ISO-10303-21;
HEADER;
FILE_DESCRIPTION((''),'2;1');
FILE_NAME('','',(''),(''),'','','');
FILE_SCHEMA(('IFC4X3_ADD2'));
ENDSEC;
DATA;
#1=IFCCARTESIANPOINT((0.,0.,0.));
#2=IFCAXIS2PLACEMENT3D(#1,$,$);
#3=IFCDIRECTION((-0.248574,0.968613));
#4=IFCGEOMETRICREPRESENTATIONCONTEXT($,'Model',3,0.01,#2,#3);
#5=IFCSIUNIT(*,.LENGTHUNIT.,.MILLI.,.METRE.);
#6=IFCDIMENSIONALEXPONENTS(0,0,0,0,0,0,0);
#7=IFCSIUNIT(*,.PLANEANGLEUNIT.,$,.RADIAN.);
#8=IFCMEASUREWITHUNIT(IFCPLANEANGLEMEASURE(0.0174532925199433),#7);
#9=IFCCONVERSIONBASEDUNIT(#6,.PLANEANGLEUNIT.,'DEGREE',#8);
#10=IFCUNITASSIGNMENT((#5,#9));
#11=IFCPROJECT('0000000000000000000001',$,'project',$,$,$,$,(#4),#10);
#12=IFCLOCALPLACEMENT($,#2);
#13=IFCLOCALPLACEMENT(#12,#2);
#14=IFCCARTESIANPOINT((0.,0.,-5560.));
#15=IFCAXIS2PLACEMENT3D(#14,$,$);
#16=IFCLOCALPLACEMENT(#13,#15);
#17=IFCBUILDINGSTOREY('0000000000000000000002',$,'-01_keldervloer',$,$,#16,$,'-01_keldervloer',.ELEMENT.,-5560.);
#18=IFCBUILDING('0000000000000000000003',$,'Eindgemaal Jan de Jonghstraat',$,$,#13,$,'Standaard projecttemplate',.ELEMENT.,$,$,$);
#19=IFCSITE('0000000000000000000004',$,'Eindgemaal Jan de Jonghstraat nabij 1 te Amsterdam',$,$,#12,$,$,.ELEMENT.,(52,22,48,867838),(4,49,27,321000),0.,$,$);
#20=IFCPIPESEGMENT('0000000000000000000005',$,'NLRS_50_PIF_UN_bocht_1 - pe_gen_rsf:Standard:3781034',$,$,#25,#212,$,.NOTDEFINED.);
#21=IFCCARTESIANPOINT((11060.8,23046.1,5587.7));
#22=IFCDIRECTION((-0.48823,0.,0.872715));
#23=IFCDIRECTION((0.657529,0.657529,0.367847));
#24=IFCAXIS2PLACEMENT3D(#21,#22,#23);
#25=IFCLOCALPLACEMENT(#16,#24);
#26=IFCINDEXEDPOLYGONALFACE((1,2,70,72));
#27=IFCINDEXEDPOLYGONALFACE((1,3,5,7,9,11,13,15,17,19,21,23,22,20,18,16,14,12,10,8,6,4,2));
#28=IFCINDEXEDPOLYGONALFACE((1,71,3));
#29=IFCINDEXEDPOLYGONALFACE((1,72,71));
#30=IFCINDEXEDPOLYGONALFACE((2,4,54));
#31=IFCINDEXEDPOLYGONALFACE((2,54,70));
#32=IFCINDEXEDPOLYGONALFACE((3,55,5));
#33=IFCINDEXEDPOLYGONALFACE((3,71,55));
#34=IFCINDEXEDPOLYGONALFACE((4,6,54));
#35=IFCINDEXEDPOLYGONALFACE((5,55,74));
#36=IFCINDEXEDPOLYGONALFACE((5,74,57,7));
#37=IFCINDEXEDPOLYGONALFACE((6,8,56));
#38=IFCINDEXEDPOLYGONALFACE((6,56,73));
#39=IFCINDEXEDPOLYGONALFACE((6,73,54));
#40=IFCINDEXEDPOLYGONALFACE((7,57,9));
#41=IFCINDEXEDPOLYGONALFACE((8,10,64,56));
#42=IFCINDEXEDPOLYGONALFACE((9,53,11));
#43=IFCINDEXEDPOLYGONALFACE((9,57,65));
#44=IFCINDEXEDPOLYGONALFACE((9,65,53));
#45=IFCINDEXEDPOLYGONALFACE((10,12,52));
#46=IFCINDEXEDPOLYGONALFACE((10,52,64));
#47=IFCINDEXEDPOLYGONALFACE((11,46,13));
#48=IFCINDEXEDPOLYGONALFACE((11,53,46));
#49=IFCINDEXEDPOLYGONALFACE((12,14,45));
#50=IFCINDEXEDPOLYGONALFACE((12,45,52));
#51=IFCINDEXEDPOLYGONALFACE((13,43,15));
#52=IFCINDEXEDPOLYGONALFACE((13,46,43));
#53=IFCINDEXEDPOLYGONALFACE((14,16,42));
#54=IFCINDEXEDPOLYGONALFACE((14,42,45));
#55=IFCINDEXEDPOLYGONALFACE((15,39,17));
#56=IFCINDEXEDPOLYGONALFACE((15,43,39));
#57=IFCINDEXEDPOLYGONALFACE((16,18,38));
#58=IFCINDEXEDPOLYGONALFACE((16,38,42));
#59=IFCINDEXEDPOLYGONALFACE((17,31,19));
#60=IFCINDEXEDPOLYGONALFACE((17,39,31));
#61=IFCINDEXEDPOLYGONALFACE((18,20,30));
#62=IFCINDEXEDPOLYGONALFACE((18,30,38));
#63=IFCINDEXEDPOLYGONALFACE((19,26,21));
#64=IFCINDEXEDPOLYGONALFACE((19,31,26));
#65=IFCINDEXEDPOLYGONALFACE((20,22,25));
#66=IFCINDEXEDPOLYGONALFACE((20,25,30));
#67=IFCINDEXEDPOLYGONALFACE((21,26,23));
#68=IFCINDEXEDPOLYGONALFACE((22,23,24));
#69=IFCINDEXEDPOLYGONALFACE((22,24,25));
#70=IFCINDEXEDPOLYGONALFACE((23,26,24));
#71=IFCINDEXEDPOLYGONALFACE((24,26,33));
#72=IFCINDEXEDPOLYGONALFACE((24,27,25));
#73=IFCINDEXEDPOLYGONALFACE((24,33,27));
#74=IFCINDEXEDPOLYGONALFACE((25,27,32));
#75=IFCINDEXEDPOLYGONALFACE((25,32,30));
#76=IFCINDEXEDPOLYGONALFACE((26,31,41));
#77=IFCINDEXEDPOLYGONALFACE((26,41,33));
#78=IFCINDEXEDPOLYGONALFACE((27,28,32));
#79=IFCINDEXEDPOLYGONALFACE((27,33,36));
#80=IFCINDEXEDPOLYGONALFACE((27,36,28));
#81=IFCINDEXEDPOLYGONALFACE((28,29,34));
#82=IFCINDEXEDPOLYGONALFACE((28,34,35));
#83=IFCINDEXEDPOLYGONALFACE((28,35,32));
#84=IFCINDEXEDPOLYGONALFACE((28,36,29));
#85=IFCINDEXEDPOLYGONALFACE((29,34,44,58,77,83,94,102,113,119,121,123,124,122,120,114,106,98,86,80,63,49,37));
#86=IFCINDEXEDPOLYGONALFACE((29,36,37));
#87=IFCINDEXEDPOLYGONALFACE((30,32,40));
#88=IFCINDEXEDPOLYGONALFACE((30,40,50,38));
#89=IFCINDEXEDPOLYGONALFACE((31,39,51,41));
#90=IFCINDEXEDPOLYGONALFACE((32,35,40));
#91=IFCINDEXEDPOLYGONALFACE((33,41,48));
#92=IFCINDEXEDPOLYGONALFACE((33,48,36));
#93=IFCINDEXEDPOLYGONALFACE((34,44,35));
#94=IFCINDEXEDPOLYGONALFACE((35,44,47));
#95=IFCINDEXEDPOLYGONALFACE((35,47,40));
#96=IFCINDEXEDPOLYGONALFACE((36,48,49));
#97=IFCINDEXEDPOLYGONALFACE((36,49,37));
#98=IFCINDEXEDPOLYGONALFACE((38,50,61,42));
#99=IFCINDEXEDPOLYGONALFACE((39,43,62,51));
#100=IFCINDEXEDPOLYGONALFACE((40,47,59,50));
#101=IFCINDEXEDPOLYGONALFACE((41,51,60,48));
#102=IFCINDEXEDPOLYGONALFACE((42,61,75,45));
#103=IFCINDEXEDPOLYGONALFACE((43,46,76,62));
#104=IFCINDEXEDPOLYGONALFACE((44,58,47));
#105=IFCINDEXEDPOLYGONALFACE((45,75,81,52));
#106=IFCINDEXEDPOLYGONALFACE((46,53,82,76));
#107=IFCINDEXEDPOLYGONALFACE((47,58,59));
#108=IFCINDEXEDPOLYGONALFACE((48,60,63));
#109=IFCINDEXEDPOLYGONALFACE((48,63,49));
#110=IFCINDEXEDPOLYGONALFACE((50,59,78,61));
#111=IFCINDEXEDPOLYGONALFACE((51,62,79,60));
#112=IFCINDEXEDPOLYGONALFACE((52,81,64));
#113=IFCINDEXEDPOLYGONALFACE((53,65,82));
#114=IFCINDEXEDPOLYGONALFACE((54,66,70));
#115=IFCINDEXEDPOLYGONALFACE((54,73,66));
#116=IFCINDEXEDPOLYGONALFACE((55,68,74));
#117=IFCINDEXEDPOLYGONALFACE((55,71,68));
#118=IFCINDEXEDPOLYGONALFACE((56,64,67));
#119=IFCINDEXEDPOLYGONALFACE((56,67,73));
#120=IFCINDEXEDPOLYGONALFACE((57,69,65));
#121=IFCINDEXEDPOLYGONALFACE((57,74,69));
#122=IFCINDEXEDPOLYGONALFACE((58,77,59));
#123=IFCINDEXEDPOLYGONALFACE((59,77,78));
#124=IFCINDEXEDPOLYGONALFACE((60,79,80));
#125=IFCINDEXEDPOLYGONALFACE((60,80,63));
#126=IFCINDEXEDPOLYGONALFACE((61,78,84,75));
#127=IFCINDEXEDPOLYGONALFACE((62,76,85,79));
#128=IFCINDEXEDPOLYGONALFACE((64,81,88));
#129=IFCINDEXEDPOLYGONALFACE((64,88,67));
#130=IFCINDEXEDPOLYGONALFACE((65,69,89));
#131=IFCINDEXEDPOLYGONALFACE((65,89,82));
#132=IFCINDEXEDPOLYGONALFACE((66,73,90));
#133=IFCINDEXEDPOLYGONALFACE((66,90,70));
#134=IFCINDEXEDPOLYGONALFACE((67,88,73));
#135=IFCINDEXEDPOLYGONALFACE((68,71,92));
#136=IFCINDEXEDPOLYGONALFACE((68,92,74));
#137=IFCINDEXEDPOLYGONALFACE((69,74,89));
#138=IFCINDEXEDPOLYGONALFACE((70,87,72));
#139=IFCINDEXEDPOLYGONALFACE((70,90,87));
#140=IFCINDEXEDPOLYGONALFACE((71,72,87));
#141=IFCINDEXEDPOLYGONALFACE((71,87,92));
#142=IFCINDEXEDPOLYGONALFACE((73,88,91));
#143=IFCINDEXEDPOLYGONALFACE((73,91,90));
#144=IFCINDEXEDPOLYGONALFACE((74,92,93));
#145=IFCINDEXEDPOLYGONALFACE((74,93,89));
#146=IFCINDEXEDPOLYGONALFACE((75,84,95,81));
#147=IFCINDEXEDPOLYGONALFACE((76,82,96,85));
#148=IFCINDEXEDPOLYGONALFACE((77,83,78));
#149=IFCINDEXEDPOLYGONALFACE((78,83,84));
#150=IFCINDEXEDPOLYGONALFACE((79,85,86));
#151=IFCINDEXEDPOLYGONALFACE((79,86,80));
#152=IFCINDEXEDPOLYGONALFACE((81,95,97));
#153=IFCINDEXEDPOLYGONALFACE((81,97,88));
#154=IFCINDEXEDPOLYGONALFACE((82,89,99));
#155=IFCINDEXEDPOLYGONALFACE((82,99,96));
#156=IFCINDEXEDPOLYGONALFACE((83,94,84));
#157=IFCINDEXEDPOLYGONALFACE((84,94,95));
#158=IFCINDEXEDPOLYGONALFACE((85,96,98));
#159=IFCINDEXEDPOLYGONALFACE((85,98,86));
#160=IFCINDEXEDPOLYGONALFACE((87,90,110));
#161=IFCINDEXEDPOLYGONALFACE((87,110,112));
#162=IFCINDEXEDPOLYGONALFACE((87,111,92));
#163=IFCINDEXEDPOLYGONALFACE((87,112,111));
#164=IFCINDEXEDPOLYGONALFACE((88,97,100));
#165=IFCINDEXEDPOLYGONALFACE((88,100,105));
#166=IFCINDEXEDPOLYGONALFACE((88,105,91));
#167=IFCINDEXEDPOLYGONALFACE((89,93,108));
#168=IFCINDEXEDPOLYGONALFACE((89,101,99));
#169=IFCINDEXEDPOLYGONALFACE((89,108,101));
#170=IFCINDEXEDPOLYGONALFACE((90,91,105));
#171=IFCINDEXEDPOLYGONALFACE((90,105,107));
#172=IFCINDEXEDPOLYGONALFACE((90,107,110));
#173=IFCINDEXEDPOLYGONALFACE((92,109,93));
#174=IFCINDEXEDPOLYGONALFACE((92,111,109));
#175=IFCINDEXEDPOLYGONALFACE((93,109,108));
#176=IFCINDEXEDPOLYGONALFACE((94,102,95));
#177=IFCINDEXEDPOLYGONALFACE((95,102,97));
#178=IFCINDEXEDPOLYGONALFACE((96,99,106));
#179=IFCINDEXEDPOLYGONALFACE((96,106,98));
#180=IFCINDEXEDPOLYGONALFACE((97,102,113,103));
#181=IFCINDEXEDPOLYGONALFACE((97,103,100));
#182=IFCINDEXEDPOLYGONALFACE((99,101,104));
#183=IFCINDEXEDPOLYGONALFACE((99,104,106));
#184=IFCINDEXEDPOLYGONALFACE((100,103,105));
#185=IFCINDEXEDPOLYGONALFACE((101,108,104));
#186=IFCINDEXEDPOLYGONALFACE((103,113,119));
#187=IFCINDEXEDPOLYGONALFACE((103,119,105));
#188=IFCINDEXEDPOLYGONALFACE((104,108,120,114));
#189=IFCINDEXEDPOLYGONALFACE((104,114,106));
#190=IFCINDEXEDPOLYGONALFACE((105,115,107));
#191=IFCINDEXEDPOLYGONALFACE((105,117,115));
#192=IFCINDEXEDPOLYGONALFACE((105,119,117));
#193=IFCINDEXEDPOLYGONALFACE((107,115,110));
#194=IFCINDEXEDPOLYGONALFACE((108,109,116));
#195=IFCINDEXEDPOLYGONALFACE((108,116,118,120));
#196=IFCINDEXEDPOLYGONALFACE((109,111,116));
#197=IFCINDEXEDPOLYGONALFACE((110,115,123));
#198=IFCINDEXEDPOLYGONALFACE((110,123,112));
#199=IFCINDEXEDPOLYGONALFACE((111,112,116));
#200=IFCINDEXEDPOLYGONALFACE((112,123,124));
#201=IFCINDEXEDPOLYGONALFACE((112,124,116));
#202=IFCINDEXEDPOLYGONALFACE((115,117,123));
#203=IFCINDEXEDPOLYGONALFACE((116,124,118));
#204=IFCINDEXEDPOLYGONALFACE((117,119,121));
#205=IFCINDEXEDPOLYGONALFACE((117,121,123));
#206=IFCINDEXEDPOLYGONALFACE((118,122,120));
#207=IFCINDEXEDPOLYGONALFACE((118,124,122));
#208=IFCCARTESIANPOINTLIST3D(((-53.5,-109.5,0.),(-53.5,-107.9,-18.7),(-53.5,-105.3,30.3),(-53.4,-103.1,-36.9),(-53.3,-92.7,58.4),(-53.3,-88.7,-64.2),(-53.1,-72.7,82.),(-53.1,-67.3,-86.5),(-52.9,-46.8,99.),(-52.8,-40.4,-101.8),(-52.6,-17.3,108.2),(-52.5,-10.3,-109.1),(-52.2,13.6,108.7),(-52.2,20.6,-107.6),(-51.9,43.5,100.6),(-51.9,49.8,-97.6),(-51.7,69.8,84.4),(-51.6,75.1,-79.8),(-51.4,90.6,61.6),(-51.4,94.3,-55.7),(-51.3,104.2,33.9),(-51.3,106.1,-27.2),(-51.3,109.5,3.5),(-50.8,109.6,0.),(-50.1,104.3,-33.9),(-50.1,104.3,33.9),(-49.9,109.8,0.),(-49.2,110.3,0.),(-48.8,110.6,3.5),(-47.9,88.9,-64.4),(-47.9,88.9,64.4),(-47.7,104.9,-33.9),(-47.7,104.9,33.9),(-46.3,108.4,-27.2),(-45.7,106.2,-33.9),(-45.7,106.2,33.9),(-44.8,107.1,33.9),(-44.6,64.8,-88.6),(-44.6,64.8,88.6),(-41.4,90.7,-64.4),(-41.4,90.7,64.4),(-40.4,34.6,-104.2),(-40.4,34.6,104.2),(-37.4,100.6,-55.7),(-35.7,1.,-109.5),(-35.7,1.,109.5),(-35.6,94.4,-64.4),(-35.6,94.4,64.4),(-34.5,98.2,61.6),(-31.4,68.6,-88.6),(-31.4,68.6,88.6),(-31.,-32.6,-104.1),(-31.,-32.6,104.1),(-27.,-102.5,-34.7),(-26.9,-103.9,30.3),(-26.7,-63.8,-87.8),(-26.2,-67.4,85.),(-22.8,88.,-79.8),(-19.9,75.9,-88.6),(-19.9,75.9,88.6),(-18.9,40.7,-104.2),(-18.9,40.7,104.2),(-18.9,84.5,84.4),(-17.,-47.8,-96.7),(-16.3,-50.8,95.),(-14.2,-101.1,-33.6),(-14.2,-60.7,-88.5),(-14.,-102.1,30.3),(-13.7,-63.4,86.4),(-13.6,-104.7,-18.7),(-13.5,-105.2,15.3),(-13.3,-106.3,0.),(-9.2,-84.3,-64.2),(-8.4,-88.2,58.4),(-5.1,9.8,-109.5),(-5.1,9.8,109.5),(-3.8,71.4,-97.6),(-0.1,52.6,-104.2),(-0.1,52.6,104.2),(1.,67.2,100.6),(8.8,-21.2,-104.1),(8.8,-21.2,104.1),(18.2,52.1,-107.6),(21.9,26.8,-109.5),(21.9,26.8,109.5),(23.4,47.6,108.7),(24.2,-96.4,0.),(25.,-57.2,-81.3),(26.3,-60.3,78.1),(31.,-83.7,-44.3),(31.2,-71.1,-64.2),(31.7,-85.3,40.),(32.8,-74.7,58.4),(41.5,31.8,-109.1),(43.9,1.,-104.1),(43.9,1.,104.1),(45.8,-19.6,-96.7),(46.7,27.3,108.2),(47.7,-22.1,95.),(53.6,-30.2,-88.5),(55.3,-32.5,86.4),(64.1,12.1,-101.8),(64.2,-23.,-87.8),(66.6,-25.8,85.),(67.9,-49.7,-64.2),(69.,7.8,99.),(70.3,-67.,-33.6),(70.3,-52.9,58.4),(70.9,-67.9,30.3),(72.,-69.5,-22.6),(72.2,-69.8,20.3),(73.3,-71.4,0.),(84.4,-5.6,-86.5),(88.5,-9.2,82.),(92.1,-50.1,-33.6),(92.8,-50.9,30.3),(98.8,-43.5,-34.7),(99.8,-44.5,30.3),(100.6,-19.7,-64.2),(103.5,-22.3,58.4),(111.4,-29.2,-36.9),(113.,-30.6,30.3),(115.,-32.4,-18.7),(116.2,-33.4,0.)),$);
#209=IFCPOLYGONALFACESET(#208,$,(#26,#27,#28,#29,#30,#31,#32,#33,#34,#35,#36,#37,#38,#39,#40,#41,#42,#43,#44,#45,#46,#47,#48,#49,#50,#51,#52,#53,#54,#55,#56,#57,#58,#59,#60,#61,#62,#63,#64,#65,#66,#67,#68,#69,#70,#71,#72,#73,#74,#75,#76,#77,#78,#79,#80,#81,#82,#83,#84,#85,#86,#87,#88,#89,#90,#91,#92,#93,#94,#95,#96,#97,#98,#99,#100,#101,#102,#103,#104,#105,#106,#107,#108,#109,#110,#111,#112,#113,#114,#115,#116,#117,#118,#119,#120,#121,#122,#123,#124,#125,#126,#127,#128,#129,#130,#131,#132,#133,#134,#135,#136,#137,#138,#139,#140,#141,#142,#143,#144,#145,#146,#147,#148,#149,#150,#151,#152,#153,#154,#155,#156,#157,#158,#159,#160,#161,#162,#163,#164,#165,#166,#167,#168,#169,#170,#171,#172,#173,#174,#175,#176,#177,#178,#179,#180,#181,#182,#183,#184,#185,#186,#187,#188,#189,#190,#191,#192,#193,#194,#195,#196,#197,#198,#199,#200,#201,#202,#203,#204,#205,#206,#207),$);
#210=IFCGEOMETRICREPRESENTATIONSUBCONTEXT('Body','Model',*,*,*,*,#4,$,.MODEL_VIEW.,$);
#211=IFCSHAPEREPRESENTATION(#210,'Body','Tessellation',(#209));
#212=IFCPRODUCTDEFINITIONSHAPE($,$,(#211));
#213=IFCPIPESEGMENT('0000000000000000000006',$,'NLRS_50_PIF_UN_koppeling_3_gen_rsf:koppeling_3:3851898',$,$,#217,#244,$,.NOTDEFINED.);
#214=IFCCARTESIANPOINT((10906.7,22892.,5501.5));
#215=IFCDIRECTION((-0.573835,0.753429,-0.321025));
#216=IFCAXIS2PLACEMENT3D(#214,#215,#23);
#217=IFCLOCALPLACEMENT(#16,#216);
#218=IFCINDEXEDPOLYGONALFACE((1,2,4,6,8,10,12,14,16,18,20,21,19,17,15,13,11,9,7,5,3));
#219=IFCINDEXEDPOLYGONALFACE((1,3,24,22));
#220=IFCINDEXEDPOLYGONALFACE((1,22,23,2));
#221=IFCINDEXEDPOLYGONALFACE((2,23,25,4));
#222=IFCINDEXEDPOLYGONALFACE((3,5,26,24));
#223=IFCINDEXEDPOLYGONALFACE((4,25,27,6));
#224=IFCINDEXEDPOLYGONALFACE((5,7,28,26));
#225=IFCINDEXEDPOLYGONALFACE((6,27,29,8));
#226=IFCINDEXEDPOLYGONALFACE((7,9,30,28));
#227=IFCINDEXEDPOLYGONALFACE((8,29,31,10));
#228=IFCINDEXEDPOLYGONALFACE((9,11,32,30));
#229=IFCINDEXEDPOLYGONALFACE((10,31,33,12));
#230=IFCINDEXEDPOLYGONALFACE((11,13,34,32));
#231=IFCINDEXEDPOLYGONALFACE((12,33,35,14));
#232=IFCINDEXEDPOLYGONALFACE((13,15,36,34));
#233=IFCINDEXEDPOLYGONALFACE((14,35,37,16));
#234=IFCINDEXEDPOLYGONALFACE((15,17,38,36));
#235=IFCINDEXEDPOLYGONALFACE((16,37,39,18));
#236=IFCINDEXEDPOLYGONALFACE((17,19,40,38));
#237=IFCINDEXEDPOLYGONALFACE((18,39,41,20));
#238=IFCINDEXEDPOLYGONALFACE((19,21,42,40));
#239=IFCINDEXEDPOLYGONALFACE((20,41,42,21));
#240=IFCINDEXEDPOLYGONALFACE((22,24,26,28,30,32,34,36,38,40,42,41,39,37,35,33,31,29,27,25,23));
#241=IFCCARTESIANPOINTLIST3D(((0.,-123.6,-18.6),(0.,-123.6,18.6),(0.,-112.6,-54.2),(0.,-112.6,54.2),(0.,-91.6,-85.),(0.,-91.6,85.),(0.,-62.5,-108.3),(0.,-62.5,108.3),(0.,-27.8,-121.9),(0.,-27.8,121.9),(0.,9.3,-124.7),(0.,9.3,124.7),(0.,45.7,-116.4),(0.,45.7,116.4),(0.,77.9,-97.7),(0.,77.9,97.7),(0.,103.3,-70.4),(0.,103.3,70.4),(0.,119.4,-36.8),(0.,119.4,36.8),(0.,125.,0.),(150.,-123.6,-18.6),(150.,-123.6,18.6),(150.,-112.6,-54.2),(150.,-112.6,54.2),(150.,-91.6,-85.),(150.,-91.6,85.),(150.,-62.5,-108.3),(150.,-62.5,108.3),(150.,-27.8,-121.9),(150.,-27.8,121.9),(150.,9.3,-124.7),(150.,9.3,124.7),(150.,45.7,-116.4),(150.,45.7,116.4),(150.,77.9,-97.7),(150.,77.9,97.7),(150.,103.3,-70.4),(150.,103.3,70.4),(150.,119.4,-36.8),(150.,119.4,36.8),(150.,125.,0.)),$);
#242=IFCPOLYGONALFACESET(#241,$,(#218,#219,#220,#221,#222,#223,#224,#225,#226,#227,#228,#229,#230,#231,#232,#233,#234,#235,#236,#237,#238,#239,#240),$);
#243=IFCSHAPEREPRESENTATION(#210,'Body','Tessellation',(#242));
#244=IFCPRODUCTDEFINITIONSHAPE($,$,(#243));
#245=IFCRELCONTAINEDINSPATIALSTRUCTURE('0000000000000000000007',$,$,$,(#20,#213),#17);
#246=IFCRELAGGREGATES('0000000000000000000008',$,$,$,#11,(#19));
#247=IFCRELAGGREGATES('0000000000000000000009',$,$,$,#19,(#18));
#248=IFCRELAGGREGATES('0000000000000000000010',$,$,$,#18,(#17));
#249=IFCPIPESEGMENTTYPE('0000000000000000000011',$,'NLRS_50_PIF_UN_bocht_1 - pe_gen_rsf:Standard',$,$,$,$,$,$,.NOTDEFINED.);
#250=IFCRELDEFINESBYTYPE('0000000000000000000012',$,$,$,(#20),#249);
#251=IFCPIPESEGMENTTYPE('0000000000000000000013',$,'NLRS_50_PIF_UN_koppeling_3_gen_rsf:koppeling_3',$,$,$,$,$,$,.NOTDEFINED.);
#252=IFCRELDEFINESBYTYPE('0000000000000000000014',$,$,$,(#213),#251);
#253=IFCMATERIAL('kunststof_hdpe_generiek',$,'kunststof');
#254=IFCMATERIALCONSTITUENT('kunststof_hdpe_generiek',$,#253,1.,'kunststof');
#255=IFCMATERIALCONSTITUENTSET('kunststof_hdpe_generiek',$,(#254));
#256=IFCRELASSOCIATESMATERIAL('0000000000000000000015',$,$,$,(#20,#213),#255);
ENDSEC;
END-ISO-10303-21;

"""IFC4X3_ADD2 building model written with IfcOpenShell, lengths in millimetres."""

from ifc_helpers import new_model, entity, si_unit, converted_unit, direction, frame, frame_2d, origin, place, context, subcontext, project, spatial, circle, extrude, source, transform, mapped, material, constituent, constituent_set, type_object, type_shapes, element, save


model = new_model("IFC4X3_ADD2")

# Units and contexts
model_context = context("Model", 3, precision=0.01, world=origin(), true_north=direction((-0.248574, 0.968613)))
body_context = subcontext(model_context, "Body", "Model", "MODEL_VIEW")
ifc_project = project(units=[si_unit("LENGTHUNIT", "METRE", prefix="MILLI"), converted_unit("PLANEANGLEUNIT", "DEGREE", entity("IfcPlaneAngleMeasure", 0.0174532925199433), si_unit("PLANEANGLEUNIT", "RADIAN"), dimensions=[0, 0, 0, 0, 0, 0, 0])], contexts=[model_context])

# Site, building, storey
site_placement = place(None, origin())
site = spatial("IfcSite", under=ifc_project, at=site_placement, Name="Eindgemaal Jan de Jonghstraat nabij 1 te Amsterdam", CompositionType="ELEMENT", RefLatitude=(52, 22, 48, 867838), RefLongitude=(4, 49, 27, 321000), RefElevation=0.0)
building_placement = place(site_placement, origin())
building = spatial("IfcBuilding", under=site, at=building_placement, Name="Eindgemaal Jan de Jonghstraat", LongName="Standaard projecttemplate", CompositionType="ELEMENT")
storey_placement = place(building_placement, frame((0.0, 0.0, -5560.0)))
storey = spatial("IfcBuildingStorey", under=building, at=storey_placement, Name="-01_keldervloer", LongName="-01_keldervloer", CompositionType="ELEMENT", Elevation=-5560.0)

# Pipe segments
ifc_material_1 = material(Name="kunststof_hdpe_generiek", Category="kunststof")
ifc_constituent_1 = constituent(ifc_material_1, Name="kunststof_hdpe_generiek", Category="kunststof", fraction=1.0)
ifc_constituent_set_1 = constituent_set(constituents=[ifc_constituent_1], Name="kunststof_hdpe_generiek")
pipe_segment_type_1 = type_object("IfcPipeSegmentType", Name="NLRS_50_PIF_UN_bocht_1 - pe_gen_rsf:Standard", PredefinedType="NOTDEFINED")
trimmed_curve = entity("IfcTrimmedCurve", entity("IfcCircle", entity("IfcAxis2Placement2D", entity("IfcCartesianPoint", [-3.2, 0.0]), entity("IfcDirection", [0.657529, 0.753429])), 3.2), [entity("IfcParameterValue", 311.111694)], [entity("IfcParameterValue", 0.0)], True, "PARAMETER")
shared_shape_1 = source(origin(), body_context, "Body", "AdvancedSweptSolid", [
    entity("IfcSurfaceCurveSweptAreaSolid", entity("IfcCircleProfileDef", "AREA", None, entity("IfcAxis2Placement2D", entity("IfcCartesianPoint", [109.5, 0.0]), entity("IfcDirection", [1.0, 0.0])), 109.5), entity("IfcAxis2Placement3D", entity("IfcCartesianPoint", [-48.8, 110.6, 0.0]), entity("IfcDirection", [0.0, 0.0, -1.0]), entity("IfcDirection", [0.753429, -0.657529, 0.0])), trimmed_curve, entity("IfcParameterValue", 0.0), entity("IfcParameterValue", 48.888306), entity("IfcSurfaceOfLinearExtrusion", entity("IfcArbitraryOpenProfileDef", "CURVE", None, trimmed_curve), entity("IfcAxis2Placement3D", entity("IfcCartesianPoint", [0.0, 0.0, -304.8])), entity("IfcDirection", [0.0, 0.0, 1.0]), 1.0)),
])
type_shapes(pipe_segment_type_1, [shared_shape_1])
pipe_segment_1_placement = place(storey_placement, frame((11060.8, 23046.1, 5587.7), z_axis=(-0.48823, 0.0, 0.872715), x_axis=(0.657529, 0.657529, 0.367847)))
element("IfcPipeSegment", 1, at=pipe_segment_1_placement, inside=storey, type_object=pipe_segment_type_1, material=ifc_constituent_set_1, Name="NLRS_50_PIF_UN_bocht_1 - pe_gen_rsf:Standard:3781034", PredefinedType="NOTDEFINED", context=body_context, shape_type="MappedRepresentation", body=[
    mapped(shared_shape_1, transform((0.0, 0.0, 0.0), scale=1.0)),
])
pipe_segment_type_2 = type_object("IfcPipeSegmentType", Name="NLRS_50_PIF_UN_koppeling_3_gen_rsf:koppeling_3", PredefinedType="NOTDEFINED")
shared_shape_2 = source(origin(), body_context, "Body", "SweptSolid", [
    extrude(circle(Radius=125.0, at=frame_2d((0.0, 0.0), x_axis=(1.0, 0.0))), frame((0.0, 0.0, 0.0), z_axis=(1.0, 0.0, 0.0), x_axis=(0.0, 1.0, 0.0)), (0.0, 0.0, 1.0), 150.0),
])
type_shapes(pipe_segment_type_2, [shared_shape_2])
pipe_segment_2_placement = place(storey_placement, frame((10906.7, 22892.0, 5501.5), z_axis=(-0.573835, 0.753429, -0.321025), x_axis=(0.657529, 0.657529, 0.367847)))
element("IfcPipeSegment", 2, at=pipe_segment_2_placement, inside=storey, type_object=pipe_segment_type_2, material=ifc_constituent_set_1, Name="NLRS_50_PIF_UN_koppeling_3_gen_rsf:koppeling_3:3851898", PredefinedType="NOTDEFINED", context=body_context, shape_type="MappedRepresentation", body=[
    mapped(shared_shape_2, transform((0.0, 0.0, 0.0), scale=1.0)),
])

save(model, "model.ifc")
